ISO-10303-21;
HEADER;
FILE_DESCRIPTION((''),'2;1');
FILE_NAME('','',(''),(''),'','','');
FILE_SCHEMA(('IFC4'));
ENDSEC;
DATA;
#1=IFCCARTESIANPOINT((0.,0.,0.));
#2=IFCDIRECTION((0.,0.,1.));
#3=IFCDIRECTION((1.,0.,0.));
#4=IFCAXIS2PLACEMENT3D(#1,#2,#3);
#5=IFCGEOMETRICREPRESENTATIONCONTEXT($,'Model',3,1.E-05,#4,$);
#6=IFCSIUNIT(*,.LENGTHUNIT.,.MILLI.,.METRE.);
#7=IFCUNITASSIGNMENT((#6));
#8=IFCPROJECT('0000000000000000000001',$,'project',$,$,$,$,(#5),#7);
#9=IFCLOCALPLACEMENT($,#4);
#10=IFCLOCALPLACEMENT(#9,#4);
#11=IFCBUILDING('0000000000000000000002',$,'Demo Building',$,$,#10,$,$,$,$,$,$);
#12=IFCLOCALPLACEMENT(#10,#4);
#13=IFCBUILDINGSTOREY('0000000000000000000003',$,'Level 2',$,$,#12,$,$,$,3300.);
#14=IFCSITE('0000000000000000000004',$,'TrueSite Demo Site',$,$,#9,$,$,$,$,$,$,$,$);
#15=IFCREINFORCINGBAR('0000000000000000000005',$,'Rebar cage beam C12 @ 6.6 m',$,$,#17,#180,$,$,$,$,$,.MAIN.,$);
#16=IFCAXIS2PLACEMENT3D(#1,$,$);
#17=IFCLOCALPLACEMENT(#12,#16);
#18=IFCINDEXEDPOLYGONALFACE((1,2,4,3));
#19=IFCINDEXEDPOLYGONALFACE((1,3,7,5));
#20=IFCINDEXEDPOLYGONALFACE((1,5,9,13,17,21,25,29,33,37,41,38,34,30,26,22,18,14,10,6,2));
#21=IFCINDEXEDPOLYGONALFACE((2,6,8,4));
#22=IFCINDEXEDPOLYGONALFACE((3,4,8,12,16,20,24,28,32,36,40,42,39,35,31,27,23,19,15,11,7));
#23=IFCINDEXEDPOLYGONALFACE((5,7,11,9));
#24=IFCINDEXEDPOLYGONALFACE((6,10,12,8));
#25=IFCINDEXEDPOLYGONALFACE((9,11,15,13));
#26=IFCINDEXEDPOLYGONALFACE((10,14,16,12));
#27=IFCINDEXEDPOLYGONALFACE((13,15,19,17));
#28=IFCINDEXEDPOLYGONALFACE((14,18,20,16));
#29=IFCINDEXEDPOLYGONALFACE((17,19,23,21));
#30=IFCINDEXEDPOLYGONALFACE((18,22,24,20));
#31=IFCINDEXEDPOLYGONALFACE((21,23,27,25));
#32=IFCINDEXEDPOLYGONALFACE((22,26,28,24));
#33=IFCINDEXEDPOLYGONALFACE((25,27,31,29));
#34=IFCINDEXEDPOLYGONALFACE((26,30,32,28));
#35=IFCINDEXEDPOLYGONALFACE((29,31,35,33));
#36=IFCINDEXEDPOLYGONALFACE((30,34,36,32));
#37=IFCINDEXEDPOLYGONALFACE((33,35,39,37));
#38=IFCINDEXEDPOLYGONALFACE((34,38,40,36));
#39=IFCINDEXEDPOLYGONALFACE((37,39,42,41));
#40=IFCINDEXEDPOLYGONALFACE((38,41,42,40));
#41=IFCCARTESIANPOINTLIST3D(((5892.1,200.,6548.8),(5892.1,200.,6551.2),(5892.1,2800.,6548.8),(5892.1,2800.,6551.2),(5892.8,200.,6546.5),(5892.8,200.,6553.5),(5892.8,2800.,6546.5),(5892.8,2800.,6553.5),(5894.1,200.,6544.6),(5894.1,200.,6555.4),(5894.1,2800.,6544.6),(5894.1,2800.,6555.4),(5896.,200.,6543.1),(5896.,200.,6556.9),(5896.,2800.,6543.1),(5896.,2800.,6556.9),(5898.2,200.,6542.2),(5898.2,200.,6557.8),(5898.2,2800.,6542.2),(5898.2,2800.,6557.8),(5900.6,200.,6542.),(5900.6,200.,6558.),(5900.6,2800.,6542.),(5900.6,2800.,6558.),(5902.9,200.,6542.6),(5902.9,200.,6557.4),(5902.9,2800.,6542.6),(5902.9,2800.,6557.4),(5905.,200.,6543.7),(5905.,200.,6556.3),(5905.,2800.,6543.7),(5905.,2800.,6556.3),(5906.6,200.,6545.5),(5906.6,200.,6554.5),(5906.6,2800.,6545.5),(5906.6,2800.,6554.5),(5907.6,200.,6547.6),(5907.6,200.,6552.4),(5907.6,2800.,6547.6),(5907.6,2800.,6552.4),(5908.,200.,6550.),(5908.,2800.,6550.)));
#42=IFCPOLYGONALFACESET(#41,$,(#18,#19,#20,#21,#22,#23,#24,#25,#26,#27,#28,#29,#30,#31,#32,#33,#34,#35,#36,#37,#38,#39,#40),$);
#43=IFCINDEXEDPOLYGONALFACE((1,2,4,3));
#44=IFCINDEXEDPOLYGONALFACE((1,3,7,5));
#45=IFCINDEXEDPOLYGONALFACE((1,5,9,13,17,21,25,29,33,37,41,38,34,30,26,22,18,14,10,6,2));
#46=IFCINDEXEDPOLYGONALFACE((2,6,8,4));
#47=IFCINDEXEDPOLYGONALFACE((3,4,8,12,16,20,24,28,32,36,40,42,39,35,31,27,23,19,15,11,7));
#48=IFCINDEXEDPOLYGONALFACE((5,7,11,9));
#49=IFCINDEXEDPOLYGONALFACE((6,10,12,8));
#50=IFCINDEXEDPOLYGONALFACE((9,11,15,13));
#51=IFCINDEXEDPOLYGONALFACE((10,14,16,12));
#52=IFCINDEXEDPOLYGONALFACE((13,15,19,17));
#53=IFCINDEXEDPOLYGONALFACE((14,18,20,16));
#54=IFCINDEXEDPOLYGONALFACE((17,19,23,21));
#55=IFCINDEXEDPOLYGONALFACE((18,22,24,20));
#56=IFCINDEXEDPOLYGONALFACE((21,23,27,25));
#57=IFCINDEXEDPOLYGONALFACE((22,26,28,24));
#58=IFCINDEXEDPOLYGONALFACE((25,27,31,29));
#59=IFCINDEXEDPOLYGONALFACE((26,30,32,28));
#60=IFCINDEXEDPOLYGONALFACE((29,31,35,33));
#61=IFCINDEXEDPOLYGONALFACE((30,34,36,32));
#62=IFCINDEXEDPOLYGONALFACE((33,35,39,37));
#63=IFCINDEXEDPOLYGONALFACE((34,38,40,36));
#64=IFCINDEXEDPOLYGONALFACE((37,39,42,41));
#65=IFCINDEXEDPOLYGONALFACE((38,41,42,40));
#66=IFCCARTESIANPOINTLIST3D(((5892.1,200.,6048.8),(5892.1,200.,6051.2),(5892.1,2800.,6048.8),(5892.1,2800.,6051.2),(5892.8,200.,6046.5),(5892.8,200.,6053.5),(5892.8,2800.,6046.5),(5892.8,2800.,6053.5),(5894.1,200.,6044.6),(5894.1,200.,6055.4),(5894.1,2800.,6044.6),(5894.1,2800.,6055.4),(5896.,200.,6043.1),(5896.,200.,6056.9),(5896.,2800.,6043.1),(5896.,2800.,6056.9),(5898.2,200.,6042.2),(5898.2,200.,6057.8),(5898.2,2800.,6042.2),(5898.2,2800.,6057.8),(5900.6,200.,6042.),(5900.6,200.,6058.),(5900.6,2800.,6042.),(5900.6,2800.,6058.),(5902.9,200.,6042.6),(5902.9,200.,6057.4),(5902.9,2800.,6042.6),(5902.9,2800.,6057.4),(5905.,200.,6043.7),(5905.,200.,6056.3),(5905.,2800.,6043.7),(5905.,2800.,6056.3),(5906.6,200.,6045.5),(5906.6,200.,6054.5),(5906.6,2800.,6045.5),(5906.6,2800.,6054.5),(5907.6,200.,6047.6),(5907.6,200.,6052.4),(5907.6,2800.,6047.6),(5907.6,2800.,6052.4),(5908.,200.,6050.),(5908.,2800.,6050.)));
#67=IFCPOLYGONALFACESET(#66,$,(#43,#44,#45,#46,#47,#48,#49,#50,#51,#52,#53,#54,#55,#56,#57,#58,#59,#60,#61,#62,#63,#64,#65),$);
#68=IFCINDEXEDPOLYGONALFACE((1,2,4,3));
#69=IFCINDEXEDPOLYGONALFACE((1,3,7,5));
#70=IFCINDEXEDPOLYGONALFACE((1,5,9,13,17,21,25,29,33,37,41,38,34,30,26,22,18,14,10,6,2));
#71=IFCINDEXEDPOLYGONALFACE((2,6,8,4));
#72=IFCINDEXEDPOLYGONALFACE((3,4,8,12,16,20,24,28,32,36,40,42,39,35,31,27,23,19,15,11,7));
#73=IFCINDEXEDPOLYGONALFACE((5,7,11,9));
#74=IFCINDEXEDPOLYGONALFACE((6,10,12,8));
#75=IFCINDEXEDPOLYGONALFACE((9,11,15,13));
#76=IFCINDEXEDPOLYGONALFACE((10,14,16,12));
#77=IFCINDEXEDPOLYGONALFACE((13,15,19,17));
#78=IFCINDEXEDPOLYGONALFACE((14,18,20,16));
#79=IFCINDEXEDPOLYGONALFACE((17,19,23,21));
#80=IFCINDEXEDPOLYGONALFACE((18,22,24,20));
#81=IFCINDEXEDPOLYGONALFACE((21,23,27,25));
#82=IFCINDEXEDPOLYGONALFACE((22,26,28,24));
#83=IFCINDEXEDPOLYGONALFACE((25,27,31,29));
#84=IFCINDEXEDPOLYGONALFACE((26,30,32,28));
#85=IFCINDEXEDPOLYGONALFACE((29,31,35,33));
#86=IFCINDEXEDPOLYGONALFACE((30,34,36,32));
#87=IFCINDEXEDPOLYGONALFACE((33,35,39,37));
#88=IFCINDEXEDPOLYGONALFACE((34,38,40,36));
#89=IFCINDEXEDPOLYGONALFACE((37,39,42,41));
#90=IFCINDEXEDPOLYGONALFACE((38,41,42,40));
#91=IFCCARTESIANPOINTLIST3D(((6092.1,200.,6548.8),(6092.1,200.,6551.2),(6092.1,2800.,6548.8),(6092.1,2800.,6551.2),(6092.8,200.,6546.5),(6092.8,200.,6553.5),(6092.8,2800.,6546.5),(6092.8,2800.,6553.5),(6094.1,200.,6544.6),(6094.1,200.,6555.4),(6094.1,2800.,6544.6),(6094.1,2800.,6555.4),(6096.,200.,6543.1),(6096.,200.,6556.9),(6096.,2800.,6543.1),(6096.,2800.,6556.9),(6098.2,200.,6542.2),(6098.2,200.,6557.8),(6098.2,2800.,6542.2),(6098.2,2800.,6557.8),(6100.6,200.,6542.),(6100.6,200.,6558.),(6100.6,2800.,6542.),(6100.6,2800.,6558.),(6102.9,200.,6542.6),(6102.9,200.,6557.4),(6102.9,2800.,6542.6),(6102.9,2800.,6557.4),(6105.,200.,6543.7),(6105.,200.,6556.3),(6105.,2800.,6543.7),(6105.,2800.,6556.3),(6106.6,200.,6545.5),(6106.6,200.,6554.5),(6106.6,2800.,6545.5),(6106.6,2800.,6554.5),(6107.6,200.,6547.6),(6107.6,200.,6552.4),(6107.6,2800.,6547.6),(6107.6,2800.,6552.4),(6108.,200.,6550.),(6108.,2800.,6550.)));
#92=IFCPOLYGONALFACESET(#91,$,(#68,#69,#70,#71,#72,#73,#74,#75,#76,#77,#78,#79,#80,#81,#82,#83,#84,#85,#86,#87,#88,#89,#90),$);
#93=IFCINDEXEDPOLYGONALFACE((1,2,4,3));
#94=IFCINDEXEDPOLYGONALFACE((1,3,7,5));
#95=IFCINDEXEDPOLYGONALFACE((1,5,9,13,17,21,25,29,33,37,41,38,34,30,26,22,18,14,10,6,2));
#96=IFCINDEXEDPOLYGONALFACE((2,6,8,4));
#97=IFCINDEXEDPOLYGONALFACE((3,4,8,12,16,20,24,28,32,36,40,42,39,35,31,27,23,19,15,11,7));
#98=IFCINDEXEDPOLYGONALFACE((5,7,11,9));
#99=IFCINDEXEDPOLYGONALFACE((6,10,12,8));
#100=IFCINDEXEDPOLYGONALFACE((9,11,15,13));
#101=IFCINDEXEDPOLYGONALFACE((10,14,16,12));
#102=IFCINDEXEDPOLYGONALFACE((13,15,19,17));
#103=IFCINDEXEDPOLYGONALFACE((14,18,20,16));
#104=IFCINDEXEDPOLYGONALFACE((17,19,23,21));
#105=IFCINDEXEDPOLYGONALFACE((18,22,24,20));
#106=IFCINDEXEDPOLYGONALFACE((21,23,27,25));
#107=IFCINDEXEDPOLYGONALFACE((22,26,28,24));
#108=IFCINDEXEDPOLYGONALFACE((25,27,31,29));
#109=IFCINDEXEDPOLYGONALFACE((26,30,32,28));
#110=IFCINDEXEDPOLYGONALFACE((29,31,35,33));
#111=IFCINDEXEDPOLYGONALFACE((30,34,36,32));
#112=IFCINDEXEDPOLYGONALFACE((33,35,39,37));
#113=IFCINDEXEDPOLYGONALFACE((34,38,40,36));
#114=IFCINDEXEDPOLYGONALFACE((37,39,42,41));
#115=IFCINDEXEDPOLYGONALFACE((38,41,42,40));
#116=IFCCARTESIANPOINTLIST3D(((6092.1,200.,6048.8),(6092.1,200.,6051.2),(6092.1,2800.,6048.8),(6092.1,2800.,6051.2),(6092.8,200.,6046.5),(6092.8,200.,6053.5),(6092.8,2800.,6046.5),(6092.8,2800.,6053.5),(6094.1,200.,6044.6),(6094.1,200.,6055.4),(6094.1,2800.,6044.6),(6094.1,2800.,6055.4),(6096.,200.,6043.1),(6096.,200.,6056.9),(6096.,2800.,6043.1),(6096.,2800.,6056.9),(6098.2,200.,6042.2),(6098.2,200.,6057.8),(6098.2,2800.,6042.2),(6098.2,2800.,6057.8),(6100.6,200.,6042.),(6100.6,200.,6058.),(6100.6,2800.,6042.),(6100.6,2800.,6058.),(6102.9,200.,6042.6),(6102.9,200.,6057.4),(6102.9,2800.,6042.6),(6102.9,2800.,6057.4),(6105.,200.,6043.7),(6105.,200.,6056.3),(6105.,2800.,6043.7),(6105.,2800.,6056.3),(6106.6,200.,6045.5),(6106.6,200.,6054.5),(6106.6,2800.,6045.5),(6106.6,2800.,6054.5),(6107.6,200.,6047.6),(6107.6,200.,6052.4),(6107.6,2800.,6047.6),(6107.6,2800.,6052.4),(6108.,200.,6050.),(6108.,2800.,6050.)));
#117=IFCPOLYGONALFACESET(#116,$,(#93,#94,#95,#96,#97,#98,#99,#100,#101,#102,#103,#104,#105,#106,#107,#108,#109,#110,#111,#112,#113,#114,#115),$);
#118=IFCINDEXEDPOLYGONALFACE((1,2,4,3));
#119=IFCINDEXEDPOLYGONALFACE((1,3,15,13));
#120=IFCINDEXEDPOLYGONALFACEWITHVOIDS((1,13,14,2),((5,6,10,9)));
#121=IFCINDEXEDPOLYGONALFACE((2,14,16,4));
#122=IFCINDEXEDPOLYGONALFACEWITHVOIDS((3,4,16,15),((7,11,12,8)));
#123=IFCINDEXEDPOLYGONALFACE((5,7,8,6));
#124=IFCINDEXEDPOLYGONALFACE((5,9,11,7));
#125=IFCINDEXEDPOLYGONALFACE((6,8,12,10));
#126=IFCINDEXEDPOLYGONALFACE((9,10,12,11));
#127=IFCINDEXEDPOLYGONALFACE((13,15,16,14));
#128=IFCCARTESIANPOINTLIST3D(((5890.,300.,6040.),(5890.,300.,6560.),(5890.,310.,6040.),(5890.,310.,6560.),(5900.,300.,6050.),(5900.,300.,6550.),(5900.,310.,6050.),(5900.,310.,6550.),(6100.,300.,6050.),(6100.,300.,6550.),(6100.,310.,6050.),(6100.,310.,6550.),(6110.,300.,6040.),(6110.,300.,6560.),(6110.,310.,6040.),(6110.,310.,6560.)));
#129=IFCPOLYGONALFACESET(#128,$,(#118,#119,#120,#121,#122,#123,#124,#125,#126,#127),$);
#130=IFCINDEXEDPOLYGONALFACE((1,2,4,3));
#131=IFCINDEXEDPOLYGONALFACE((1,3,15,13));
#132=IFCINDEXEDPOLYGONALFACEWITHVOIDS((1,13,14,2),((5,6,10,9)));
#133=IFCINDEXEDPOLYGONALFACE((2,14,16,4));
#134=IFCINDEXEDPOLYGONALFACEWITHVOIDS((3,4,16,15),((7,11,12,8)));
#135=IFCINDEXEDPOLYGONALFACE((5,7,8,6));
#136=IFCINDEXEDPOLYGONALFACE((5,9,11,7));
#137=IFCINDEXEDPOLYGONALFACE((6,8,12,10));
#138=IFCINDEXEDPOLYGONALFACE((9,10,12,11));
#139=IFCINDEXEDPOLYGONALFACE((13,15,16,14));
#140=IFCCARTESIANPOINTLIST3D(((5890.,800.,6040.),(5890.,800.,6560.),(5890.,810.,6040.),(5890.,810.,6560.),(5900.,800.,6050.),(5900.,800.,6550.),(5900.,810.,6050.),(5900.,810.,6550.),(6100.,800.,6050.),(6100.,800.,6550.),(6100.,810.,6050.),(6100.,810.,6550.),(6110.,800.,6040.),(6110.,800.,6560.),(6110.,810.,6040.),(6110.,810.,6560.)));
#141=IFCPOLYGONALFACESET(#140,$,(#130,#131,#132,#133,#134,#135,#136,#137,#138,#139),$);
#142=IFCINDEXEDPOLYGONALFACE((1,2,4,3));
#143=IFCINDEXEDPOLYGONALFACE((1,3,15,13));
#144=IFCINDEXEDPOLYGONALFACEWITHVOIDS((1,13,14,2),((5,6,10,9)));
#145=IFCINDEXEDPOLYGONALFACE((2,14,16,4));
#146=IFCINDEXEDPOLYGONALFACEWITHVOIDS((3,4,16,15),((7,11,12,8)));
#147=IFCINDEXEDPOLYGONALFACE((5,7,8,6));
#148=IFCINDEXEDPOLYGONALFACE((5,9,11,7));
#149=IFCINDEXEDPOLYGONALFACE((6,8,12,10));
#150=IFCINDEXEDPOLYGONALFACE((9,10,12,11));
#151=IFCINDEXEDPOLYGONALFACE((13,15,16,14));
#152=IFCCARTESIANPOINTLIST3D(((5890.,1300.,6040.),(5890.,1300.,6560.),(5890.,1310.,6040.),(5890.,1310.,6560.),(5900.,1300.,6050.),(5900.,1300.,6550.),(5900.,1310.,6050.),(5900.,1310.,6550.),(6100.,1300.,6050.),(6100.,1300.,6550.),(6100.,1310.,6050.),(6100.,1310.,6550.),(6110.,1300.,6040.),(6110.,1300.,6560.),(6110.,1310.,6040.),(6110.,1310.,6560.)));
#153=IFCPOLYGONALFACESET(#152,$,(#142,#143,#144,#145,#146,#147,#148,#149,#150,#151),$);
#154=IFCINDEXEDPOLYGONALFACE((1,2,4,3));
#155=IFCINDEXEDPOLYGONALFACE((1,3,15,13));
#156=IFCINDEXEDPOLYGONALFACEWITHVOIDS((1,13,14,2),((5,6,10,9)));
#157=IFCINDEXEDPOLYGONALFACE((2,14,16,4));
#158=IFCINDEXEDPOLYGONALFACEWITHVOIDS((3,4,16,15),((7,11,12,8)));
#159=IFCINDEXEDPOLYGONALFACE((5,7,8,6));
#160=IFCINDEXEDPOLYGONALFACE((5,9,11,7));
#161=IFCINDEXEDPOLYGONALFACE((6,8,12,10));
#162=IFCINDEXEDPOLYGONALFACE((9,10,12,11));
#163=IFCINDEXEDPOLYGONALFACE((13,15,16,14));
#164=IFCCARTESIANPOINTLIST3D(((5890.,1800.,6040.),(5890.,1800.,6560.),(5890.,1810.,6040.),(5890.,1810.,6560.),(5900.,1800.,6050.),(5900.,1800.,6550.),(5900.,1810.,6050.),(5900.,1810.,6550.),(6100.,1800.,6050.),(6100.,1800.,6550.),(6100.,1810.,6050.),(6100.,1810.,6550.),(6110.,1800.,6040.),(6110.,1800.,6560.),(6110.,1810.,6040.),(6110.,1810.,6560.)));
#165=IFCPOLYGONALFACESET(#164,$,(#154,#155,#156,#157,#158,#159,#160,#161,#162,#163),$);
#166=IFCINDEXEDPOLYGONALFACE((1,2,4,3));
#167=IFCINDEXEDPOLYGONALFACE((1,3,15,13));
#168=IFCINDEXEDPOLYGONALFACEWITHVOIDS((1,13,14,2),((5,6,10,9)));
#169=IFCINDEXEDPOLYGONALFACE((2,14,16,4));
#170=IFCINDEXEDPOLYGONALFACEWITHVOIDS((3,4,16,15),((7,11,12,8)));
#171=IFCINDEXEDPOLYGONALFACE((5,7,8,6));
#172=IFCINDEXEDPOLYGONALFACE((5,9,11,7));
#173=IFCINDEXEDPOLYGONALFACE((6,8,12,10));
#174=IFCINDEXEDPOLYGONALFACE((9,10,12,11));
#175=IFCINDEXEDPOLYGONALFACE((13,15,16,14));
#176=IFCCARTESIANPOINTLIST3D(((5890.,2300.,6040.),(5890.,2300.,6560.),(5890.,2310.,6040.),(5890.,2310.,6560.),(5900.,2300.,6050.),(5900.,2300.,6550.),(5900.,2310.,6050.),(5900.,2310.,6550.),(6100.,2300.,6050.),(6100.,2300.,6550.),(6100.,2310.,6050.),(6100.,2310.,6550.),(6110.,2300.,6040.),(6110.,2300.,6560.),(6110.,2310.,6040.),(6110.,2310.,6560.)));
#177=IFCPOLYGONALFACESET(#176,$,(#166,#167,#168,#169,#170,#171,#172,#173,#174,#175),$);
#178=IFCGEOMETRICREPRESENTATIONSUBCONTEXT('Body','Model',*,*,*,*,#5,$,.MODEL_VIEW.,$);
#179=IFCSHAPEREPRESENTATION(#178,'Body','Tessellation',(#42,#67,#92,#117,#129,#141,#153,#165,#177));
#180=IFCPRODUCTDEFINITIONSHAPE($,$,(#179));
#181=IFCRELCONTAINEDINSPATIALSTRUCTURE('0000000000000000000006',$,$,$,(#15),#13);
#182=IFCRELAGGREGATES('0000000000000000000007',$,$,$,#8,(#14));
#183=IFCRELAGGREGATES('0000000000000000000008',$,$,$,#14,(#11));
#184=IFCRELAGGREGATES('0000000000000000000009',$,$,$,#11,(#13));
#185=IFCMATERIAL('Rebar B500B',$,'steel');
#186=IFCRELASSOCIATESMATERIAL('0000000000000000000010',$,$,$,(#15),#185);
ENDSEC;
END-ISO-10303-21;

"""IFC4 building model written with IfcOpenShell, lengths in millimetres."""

from ifc_helpers import new_model, si_unit, frame, origin_with_axes, place, context, subcontext, project, spatial, hollow_rectangle, circle, extrude, material, element, save


model = new_model("IFC4")

# Units and contexts
model_context = context("Model", 3, precision=1e-05, world=origin_with_axes())
body_context = subcontext(model_context, "Body", "Model", "MODEL_VIEW")
ifc_project = project(units=[si_unit("LENGTHUNIT", "METRE", prefix="MILLI")], contexts=[model_context])

# Site, building, storey
site_placement = place(None, origin_with_axes())
site = spatial("IfcSite", under=ifc_project, at=site_placement, Name="TrueSite Demo Site")
building_placement = place(site_placement, origin_with_axes())
building = spatial("IfcBuilding", under=site, at=building_placement, Name="Demo Building")
storey_placement = place(building_placement, origin_with_axes())
storey = spatial("IfcBuildingStorey", under=building, at=storey_placement, Name="Level 2", Elevation=3300.0)

# Reinforcing bar
ifc_material_1 = material(Name="Rebar B500B", Category="steel")
for number, where, z_axis, x_axis, name in (
    (1, (6000.0, 200.0, 6300.0), (0.0, 1.0, 0.0), (1.0, 0.0, 0.0), "Rebar cage beam C12 @ 6.6 m"),
):
    element("IfcReinforcingBar", number, at=place(storey_placement, frame(where, z_axis=z_axis, x_axis=x_axis)), inside=storey, material=ifc_material_1, Name=name, PredefinedType="MAIN", context=body_context, shape_type="SweptSolid", body=[
        extrude(circle(Radius=8.0), frame((-100.0, -250.0, 0.0)), (0.0, 0.0, 1.0), 2600.0),
        extrude(circle(Radius=8.0), frame((-100.0, 250.0, 0.0)), (0.0, 0.0, 1.0), 2600.0),
        extrude(circle(Radius=8.0), frame((100.0, -250.0, 0.0)), (0.0, 0.0, 1.0), 2600.0),
        extrude(circle(Radius=8.0), frame((100.0, 250.0, 0.0)), (0.0, 0.0, 1.0), 2600.0),
        extrude(hollow_rectangle(XDim=220.0, YDim=520.0, WallThickness=10.0), frame((0.0, 0.0, 100.0)), (0.0, 0.0, 1.0), 10.0),
        extrude(hollow_rectangle(XDim=220.0, YDim=520.0, WallThickness=10.0), frame((0.0, 0.0, 600.0)), (0.0, 0.0, 1.0), 10.0),
        extrude(hollow_rectangle(XDim=220.0, YDim=520.0, WallThickness=10.0), frame((0.0, 0.0, 1100.0)), (0.0, 0.0, 1.0), 10.0),
        extrude(hollow_rectangle(XDim=220.0, YDim=520.0, WallThickness=10.0), frame((0.0, 0.0, 1600.0)), (0.0, 0.0, 1.0), 10.0),
        extrude(hollow_rectangle(XDim=220.0, YDim=520.0, WallThickness=10.0), frame((0.0, 0.0, 2100.0)), (0.0, 0.0, 1.0), 10.0),
    ])

save(model, "model.ifc")
